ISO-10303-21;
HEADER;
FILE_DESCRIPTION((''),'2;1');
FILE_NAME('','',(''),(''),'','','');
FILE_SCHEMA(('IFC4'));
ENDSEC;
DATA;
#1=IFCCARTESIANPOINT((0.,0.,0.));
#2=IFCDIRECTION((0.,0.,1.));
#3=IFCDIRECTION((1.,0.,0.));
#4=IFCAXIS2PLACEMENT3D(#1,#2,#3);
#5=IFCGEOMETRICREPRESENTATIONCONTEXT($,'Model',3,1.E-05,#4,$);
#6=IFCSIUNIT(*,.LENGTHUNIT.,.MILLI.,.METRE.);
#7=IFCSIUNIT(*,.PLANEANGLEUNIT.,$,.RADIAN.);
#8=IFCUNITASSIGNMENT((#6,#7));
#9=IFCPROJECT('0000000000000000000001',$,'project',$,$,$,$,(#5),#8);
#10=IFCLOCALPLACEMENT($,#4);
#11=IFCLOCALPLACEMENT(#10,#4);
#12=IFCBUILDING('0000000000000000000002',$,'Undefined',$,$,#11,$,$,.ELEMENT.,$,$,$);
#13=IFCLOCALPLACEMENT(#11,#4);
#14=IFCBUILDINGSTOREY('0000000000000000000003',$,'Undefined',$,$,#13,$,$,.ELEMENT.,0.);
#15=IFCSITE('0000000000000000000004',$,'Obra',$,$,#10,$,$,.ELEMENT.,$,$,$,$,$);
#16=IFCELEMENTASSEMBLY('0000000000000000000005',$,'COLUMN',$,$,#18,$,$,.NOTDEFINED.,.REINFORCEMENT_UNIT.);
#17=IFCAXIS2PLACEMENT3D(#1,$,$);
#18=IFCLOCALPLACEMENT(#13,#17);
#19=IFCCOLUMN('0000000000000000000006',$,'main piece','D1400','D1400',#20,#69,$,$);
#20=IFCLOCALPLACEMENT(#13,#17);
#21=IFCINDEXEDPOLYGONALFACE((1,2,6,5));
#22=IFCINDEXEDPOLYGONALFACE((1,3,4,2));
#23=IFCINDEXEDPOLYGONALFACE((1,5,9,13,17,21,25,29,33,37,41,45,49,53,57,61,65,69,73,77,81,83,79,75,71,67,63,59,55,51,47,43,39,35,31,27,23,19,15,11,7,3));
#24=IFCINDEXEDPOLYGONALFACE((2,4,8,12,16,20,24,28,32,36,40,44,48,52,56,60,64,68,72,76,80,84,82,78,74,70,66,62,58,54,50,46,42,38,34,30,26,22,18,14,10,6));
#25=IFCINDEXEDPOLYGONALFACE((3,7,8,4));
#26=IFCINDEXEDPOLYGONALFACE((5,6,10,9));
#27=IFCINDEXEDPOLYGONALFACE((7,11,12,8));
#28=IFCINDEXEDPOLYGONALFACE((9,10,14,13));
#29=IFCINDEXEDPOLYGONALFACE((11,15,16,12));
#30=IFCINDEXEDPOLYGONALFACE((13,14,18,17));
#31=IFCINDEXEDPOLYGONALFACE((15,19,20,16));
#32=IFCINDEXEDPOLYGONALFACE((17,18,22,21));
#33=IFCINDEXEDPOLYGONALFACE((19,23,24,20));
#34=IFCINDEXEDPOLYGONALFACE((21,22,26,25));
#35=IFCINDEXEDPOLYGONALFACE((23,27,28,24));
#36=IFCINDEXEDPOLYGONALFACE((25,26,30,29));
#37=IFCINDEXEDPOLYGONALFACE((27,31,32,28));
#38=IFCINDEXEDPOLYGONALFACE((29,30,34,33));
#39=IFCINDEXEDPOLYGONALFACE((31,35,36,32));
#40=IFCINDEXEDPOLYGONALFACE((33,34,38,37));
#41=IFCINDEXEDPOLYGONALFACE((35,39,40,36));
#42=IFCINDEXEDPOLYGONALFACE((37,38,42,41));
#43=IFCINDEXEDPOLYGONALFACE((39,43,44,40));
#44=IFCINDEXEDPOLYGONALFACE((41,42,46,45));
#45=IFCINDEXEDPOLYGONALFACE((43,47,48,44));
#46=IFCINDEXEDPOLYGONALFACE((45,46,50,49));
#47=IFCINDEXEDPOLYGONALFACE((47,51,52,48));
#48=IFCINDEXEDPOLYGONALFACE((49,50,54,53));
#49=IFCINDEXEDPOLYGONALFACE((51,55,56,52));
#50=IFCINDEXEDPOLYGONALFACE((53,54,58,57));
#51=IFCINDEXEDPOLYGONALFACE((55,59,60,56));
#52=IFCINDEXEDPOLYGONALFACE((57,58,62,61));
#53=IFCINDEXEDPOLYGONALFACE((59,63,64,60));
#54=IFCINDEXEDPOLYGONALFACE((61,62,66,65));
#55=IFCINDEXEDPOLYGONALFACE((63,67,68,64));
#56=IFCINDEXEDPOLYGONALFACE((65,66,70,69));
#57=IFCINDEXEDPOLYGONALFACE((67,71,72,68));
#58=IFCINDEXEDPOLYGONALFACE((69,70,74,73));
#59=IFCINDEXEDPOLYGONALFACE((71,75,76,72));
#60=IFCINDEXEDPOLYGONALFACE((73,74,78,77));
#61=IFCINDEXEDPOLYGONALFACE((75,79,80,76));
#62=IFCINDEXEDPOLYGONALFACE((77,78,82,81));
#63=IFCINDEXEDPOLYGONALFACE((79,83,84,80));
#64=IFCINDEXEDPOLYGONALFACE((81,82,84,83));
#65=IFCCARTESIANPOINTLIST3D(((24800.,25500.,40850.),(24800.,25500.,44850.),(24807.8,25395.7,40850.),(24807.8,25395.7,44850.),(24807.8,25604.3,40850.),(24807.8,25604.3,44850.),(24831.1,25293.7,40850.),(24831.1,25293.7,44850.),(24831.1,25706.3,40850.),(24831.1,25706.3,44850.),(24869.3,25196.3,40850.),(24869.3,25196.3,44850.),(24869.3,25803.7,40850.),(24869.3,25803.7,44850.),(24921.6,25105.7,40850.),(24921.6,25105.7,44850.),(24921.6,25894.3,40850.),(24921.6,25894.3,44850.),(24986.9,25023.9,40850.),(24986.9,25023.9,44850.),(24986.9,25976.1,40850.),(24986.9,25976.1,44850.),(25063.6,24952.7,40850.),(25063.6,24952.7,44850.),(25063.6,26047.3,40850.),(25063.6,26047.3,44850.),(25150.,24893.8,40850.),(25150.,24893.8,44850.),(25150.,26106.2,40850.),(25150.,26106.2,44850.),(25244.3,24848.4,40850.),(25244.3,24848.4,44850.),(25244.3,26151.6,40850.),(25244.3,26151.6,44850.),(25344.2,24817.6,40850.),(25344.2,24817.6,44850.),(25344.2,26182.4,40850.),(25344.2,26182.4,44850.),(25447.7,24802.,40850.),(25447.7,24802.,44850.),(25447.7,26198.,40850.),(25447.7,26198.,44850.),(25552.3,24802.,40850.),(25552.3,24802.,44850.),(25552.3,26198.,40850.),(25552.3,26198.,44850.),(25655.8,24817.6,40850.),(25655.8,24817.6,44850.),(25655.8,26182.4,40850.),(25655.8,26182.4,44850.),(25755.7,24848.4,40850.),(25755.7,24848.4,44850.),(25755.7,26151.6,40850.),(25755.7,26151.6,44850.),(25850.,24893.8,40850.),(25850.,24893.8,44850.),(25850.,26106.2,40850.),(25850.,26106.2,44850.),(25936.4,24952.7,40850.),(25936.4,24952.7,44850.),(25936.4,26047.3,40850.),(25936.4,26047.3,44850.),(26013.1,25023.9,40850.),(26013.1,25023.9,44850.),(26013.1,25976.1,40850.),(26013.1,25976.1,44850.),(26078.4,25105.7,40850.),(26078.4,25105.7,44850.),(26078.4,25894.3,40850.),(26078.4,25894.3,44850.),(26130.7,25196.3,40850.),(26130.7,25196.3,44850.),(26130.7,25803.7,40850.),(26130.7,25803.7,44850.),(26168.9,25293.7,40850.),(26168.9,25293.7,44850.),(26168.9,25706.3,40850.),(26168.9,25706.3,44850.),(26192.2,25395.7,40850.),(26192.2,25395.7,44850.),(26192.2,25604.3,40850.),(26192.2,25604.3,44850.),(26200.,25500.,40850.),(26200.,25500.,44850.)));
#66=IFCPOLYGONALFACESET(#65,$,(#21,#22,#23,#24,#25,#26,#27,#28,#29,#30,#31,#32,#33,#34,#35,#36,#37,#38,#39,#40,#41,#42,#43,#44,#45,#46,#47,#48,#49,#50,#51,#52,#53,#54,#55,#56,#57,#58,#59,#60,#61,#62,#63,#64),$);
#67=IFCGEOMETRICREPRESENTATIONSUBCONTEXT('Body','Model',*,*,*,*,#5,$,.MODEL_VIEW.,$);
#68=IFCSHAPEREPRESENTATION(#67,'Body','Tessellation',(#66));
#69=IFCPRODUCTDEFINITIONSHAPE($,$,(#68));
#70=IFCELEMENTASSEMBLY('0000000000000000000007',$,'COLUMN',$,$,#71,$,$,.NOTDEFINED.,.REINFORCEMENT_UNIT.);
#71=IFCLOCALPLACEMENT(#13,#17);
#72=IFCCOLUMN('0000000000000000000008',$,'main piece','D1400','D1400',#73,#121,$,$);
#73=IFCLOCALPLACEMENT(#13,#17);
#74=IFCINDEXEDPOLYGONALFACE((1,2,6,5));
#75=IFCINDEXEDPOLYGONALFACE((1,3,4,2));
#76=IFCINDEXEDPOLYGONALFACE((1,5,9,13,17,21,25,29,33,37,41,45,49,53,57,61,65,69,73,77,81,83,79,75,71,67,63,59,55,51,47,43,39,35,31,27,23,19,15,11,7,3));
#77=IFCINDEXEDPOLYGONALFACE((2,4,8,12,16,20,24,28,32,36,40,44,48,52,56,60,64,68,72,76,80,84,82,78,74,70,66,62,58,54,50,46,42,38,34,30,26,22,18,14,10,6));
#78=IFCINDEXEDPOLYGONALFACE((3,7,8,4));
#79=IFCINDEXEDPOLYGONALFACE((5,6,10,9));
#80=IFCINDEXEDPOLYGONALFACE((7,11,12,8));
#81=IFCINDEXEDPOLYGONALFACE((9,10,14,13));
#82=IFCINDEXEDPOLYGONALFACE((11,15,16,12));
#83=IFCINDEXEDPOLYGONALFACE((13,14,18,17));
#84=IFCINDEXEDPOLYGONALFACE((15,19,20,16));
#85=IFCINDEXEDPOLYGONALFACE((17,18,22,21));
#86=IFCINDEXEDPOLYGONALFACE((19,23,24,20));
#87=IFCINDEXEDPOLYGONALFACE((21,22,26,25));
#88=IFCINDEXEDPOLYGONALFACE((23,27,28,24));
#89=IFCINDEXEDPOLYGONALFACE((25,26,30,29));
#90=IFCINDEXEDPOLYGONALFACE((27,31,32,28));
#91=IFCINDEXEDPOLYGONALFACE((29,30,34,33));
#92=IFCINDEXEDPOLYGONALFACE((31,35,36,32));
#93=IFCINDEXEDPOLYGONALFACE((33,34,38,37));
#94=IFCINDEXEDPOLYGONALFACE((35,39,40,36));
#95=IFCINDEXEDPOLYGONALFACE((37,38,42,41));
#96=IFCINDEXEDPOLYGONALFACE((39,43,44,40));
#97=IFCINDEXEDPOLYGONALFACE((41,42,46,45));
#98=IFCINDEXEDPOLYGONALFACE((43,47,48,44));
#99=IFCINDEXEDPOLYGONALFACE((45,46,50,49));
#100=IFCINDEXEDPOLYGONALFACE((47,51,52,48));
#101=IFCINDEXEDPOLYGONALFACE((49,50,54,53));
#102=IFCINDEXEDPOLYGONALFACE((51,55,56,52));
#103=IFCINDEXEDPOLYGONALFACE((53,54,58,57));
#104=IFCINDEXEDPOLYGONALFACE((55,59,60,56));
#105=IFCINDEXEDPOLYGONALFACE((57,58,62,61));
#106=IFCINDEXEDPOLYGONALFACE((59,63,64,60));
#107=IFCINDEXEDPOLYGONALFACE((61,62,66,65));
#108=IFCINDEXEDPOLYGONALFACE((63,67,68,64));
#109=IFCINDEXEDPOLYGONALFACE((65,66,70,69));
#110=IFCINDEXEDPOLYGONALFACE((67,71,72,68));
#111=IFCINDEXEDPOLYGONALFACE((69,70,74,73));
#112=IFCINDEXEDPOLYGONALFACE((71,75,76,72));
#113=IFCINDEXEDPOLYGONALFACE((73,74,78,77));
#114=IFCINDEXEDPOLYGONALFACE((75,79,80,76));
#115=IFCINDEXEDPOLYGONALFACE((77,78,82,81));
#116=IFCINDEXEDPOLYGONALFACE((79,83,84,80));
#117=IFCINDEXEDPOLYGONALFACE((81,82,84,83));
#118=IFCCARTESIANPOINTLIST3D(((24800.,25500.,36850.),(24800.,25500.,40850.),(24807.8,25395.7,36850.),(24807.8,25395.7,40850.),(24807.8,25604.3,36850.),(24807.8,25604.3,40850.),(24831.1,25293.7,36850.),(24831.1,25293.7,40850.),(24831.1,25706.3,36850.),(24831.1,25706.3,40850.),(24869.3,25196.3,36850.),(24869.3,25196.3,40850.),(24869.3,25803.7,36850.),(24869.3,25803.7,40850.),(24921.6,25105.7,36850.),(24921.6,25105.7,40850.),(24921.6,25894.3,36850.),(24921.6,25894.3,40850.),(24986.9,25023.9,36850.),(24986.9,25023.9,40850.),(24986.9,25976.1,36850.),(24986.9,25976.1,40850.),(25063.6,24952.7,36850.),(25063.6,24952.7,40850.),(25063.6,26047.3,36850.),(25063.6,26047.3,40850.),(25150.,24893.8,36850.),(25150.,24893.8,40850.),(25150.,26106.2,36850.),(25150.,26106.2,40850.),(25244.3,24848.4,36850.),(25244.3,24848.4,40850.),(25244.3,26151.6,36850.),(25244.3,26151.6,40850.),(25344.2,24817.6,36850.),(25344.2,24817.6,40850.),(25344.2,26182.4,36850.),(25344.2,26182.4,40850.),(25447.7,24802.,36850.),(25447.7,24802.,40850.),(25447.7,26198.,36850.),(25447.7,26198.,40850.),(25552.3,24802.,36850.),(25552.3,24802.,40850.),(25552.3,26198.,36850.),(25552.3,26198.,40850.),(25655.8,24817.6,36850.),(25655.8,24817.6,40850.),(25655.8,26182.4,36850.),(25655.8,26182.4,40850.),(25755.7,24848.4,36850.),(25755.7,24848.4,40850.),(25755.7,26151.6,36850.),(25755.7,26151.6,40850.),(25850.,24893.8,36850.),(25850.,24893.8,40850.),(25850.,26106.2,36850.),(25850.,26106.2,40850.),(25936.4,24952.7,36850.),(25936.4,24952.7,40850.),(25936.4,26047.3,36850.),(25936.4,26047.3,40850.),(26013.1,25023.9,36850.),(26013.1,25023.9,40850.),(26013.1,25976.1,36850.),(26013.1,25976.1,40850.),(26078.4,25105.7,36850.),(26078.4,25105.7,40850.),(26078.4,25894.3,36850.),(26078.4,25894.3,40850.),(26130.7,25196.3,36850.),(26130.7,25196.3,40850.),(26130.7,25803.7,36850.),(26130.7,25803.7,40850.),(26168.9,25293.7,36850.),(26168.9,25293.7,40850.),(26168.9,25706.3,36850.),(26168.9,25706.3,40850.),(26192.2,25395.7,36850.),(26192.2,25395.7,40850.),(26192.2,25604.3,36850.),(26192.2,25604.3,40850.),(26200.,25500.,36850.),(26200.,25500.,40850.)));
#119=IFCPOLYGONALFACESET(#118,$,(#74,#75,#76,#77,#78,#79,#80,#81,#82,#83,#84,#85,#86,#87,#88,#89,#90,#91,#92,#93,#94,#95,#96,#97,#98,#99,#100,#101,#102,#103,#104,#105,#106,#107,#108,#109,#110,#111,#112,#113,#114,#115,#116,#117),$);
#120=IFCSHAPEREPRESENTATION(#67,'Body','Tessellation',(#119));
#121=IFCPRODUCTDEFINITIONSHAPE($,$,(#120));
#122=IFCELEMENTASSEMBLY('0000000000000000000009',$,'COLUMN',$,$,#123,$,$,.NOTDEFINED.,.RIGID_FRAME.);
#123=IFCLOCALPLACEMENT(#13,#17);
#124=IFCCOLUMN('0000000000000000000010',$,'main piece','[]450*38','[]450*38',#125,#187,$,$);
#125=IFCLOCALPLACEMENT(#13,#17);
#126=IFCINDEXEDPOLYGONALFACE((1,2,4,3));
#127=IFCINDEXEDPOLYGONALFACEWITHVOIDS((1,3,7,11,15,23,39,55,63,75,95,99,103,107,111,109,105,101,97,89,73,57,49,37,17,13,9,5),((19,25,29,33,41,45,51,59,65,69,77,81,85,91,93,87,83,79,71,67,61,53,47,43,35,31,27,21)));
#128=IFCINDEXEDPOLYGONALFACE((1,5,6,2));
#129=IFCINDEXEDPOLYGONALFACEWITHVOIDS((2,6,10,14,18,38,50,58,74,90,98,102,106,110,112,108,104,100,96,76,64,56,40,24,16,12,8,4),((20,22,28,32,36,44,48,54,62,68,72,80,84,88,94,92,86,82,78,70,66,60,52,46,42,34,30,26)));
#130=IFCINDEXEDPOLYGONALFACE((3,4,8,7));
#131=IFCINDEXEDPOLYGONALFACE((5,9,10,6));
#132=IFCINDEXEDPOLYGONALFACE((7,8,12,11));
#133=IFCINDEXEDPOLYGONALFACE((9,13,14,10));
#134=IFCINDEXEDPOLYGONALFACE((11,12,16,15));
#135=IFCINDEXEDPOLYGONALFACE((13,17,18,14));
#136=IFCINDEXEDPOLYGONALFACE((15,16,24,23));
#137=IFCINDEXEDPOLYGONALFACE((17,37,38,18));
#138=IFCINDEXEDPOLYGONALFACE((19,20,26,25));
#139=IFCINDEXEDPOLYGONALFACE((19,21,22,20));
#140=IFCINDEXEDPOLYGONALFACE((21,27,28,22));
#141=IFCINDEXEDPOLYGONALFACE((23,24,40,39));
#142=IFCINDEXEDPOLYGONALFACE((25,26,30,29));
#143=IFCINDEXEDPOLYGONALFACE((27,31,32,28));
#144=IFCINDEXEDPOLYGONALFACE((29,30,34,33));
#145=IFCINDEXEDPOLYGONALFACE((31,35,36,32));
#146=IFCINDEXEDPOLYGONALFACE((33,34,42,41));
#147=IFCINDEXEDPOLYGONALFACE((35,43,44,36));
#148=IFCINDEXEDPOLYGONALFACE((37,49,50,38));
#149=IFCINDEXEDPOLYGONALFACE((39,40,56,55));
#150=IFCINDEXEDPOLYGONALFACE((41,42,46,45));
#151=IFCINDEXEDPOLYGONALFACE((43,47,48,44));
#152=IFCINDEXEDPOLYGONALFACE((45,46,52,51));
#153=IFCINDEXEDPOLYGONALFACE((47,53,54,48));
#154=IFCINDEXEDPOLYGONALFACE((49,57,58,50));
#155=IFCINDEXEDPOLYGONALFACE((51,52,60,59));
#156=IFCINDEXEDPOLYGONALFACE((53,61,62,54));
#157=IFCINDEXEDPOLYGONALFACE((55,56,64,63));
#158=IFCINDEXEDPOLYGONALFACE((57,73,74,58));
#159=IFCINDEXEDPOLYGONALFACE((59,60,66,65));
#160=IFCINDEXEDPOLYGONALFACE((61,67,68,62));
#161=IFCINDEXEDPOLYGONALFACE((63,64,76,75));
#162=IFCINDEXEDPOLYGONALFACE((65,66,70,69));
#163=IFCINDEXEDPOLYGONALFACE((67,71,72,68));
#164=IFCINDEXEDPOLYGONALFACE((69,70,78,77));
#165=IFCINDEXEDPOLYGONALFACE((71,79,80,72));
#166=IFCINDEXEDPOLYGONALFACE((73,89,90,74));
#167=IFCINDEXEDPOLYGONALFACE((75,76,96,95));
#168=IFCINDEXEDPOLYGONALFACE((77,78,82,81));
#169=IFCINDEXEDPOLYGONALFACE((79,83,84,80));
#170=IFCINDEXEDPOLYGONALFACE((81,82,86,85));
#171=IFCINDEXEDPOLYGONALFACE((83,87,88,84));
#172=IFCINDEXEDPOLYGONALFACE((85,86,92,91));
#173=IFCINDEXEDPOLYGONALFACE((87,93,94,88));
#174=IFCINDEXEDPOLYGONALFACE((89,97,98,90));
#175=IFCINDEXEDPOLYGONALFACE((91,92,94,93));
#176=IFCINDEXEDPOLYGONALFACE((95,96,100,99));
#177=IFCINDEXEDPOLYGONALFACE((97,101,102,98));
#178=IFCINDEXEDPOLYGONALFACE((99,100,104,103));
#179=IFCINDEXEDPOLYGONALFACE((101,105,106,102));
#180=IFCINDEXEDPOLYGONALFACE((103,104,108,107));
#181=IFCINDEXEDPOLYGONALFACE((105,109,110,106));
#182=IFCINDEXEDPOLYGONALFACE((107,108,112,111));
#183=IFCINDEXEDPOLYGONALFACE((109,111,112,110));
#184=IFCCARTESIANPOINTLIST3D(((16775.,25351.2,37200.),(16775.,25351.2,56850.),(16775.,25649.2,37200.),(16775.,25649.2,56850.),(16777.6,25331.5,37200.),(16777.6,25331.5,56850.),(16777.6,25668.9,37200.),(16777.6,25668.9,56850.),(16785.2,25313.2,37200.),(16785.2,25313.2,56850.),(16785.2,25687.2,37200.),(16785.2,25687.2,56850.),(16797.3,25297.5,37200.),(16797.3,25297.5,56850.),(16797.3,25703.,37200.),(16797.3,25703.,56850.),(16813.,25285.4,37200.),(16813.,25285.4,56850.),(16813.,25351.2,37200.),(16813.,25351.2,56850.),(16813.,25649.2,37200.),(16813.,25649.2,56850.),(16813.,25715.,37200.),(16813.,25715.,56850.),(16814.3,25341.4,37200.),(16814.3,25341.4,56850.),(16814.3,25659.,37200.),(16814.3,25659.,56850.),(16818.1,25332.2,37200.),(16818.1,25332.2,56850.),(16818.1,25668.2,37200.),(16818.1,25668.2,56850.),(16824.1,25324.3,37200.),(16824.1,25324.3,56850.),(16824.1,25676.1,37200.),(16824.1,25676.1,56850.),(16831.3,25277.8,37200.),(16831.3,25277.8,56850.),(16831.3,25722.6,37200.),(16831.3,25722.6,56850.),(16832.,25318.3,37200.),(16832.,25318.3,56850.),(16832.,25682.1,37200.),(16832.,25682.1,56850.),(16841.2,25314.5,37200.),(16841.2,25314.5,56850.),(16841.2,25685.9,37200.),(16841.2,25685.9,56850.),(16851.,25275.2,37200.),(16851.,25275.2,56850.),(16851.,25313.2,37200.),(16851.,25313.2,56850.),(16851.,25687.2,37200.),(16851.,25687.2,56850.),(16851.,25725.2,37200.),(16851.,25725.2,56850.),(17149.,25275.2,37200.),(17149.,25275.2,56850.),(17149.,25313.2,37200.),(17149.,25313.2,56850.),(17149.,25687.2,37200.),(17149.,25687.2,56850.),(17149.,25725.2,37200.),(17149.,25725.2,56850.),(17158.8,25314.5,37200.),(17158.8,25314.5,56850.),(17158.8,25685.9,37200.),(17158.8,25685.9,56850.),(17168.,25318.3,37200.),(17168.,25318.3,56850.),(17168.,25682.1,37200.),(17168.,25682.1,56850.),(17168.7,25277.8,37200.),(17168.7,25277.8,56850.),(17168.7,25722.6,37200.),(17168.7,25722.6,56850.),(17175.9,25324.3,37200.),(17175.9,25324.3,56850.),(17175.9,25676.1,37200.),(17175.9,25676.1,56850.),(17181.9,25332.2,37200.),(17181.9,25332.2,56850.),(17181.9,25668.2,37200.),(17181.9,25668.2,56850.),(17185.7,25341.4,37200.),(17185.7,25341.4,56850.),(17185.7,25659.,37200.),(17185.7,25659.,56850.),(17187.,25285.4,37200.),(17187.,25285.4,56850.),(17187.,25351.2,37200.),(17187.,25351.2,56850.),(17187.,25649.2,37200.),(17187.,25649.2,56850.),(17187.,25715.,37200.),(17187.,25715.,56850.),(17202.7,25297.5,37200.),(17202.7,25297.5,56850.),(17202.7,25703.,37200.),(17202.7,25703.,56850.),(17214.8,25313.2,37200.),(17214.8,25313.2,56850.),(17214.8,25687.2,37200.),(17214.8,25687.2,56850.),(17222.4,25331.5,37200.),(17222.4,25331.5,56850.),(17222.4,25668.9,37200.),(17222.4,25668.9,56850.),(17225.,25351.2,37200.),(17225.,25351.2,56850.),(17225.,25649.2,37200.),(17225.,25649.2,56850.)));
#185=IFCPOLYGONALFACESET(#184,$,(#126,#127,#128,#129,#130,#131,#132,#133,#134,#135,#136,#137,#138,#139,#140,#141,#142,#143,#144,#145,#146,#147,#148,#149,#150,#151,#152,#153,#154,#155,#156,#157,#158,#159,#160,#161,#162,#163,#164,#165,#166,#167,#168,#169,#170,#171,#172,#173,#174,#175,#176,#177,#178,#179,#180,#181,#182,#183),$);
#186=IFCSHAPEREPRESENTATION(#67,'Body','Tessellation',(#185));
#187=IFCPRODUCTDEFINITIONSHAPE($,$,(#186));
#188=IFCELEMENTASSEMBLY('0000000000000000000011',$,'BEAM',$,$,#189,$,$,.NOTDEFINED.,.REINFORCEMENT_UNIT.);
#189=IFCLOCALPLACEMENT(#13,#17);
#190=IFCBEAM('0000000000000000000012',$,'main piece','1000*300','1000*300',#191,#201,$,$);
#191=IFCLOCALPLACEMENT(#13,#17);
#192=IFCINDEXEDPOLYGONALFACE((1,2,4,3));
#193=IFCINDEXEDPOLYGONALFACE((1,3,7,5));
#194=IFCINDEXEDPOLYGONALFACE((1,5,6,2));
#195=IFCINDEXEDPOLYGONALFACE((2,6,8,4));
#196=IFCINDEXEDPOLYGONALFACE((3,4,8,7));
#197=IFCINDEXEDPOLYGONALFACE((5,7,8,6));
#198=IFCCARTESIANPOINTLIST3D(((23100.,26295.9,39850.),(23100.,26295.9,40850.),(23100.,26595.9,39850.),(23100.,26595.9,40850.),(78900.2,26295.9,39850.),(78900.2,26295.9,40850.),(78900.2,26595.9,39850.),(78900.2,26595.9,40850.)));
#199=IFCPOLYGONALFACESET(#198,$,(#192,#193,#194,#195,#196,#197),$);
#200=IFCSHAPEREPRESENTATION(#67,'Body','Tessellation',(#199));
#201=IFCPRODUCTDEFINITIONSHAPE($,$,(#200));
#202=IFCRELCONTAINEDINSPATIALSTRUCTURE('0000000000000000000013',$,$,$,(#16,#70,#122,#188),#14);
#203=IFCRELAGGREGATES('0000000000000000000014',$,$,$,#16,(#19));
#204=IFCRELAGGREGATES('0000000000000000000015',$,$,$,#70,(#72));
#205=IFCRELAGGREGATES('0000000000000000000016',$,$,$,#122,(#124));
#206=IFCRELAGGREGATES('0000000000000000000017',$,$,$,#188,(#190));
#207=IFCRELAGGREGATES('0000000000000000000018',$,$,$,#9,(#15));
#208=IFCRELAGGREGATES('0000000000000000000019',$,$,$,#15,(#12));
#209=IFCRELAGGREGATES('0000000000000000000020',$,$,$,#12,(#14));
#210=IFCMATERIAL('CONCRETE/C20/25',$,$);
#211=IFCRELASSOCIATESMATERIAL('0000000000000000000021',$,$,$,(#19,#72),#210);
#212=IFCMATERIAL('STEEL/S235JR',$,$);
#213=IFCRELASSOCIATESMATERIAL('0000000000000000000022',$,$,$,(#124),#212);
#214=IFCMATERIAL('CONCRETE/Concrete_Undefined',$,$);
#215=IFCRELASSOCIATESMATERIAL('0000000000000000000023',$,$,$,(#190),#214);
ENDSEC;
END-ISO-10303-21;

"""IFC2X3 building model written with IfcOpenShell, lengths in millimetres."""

from ifc_helpers import new_model, si_unit, frame, origin_with_axes, origin_2d_with_axis, place, context, subcontext, project, spatial, rectangle, hollow_rectangle, circle, extrude, material, element, aggregate, save


model = new_model("IFC2X3")

# Units and contexts
model_context = context("Model", 3, precision=1e-05, world=origin_with_axes())
body_context = subcontext(model_context, "Body", "Model", "MODEL_VIEW")
ifc_project = project(units=[si_unit("LENGTHUNIT", "METRE", prefix="MILLI"), si_unit("PLANEANGLEUNIT", "RADIAN")], contexts=[model_context])

# Site, building, storey
site_placement = place(None, origin_with_axes())
site = spatial("IfcSite", under=ifc_project, at=site_placement, Name="Obra", CompositionType="ELEMENT")
building_placement = place(site_placement, origin_with_axes())
building = spatial("IfcBuilding", under=site, at=building_placement, Name="Undefined", CompositionType="ELEMENT")
storey_placement = place(building_placement, origin_with_axes())
storey = spatial("IfcBuildingStorey", under=building, at=storey_placement, Name="Undefined", CompositionType="ELEMENT", Elevation=0.0)

# Element assemblies, columns
assembly_1_placement = place(storey_placement, origin_with_axes())
assembly_1 = element("IfcElementAssembly", 1, at=assembly_1_placement, inside=storey, Name="COLUMN", AssemblyPlace="NOTDEFINED", PredefinedType="REINFORCEMENT_UNIT")
ifc_material_1 = material(Name="CONCRETE/C20/25")
column_1_placement = place(assembly_1_placement, frame((25500.0, 25500.0, 40850.0), z_axis=(0.0, 0.0, 1.0), x_axis=(0.0, 1.0, 0.0)))
column_1 = element("IfcColumn", 2, at=column_1_placement, material=ifc_material_1, Name="main piece", Description="D1400", ObjectType="D1400", context=body_context, shape_type="SweptSolid", body=[
    extrude(circle(Radius=700.0, at=origin_2d_with_axis()), frame((0.0, 0.0, 4000.0), z_axis=(0.0, 0.0, -1.0), x_axis=(0.0, 1.0, 0.0)), (0.0, 0.0, 1.0), 4000.0),
])
aggregate(assembly_1, [column_1])
assembly_2_placement = place(storey_placement, origin_with_axes())
assembly_2 = element("IfcElementAssembly", 3, at=assembly_2_placement, inside=storey, Name="COLUMN", AssemblyPlace="NOTDEFINED", PredefinedType="REINFORCEMENT_UNIT")
column_2_placement = place(assembly_2_placement, frame((25500.0, 25500.0, 36850.0), z_axis=(0.0, 0.0, 1.0), x_axis=(0.0, 1.0, 0.0)))
column_2 = element("IfcColumn", 4, at=column_2_placement, material=ifc_material_1, Name="main piece", Description="D1400", ObjectType="D1400", context=body_context, shape_type="SweptSolid", body=[
    extrude(circle(Radius=700.0, at=origin_2d_with_axis()), frame((0.0, 0.0, 4000.0), z_axis=(0.0, 0.0, -1.0), x_axis=(0.0, 1.0, 0.0)), (0.0, 0.0, 1.0), 4000.0),
])
aggregate(assembly_2, [column_2])
assembly_3_placement = place(storey_placement, origin_with_axes())
assembly_3 = element("IfcElementAssembly", 5, at=assembly_3_placement, inside=storey, Name="COLUMN", AssemblyPlace="NOTDEFINED", PredefinedType="RIGID_FRAME")
ifc_material_2 = material(Name="STEEL/S235JR")
column_3_placement = place(assembly_3_placement, frame((17000.0, 25500.2, 37200.0), z_axis=(0.0, 0.0, 1.0), x_axis=(0.0, 1.0, 0.0)))
column_3 = element("IfcColumn", 6, at=column_3_placement, material=ifc_material_2, Name="main piece", Description="[]450*38", ObjectType="[]450*38", context=body_context, shape_type="SweptSolid", body=[
    extrude(hollow_rectangle(XDim=450.0, YDim=450.0, WallThickness=38.0, InnerFilletRadius=38.0, OuterFilletRadius=76.0, at=origin_2d_with_axis()), frame((0.0, 0.0, 19650.0), z_axis=(0.0, 0.0, -1.0), x_axis=(0.0, 1.0, 0.0)), (0.0, 0.0, 1.0), 19650.0),
])
aggregate(assembly_3, [column_3])

# Element assembly, beam
assembly_4_placement = place(storey_placement, origin_with_axes())
assembly_4 = element("IfcElementAssembly", 7, at=assembly_4_placement, inside=storey, Name="BEAM", AssemblyPlace="NOTDEFINED", PredefinedType="REINFORCEMENT_UNIT")
ifc_material_3 = material(Name="CONCRETE/Concrete_Undefined")
beam_1_placement = place(assembly_4_placement, frame((23100.0, 26445.9, 40350.0), z_axis=(0.0, 0.0, 1.0), x_axis=(1.0, 0.0, 0.0)))
beam_1 = element("IfcBeam", 8, at=beam_1_placement, material=ifc_material_3, Name="main piece", Description="1000*300", ObjectType="1000*300", context=body_context, shape_type="SweptSolid", body=[
    extrude(rectangle(XDim=300.0, YDim=1000.0, at=origin_2d_with_axis()), frame((55800.2, 0.0, 0.0), z_axis=(-1.0, 0.0, 0.0), x_axis=(0.0, -1.0, 0.0)), (0.0, 0.0, 1.0), 55800.2),
])
aggregate(assembly_4, [beam_1])

save(model, "model.ifc")
